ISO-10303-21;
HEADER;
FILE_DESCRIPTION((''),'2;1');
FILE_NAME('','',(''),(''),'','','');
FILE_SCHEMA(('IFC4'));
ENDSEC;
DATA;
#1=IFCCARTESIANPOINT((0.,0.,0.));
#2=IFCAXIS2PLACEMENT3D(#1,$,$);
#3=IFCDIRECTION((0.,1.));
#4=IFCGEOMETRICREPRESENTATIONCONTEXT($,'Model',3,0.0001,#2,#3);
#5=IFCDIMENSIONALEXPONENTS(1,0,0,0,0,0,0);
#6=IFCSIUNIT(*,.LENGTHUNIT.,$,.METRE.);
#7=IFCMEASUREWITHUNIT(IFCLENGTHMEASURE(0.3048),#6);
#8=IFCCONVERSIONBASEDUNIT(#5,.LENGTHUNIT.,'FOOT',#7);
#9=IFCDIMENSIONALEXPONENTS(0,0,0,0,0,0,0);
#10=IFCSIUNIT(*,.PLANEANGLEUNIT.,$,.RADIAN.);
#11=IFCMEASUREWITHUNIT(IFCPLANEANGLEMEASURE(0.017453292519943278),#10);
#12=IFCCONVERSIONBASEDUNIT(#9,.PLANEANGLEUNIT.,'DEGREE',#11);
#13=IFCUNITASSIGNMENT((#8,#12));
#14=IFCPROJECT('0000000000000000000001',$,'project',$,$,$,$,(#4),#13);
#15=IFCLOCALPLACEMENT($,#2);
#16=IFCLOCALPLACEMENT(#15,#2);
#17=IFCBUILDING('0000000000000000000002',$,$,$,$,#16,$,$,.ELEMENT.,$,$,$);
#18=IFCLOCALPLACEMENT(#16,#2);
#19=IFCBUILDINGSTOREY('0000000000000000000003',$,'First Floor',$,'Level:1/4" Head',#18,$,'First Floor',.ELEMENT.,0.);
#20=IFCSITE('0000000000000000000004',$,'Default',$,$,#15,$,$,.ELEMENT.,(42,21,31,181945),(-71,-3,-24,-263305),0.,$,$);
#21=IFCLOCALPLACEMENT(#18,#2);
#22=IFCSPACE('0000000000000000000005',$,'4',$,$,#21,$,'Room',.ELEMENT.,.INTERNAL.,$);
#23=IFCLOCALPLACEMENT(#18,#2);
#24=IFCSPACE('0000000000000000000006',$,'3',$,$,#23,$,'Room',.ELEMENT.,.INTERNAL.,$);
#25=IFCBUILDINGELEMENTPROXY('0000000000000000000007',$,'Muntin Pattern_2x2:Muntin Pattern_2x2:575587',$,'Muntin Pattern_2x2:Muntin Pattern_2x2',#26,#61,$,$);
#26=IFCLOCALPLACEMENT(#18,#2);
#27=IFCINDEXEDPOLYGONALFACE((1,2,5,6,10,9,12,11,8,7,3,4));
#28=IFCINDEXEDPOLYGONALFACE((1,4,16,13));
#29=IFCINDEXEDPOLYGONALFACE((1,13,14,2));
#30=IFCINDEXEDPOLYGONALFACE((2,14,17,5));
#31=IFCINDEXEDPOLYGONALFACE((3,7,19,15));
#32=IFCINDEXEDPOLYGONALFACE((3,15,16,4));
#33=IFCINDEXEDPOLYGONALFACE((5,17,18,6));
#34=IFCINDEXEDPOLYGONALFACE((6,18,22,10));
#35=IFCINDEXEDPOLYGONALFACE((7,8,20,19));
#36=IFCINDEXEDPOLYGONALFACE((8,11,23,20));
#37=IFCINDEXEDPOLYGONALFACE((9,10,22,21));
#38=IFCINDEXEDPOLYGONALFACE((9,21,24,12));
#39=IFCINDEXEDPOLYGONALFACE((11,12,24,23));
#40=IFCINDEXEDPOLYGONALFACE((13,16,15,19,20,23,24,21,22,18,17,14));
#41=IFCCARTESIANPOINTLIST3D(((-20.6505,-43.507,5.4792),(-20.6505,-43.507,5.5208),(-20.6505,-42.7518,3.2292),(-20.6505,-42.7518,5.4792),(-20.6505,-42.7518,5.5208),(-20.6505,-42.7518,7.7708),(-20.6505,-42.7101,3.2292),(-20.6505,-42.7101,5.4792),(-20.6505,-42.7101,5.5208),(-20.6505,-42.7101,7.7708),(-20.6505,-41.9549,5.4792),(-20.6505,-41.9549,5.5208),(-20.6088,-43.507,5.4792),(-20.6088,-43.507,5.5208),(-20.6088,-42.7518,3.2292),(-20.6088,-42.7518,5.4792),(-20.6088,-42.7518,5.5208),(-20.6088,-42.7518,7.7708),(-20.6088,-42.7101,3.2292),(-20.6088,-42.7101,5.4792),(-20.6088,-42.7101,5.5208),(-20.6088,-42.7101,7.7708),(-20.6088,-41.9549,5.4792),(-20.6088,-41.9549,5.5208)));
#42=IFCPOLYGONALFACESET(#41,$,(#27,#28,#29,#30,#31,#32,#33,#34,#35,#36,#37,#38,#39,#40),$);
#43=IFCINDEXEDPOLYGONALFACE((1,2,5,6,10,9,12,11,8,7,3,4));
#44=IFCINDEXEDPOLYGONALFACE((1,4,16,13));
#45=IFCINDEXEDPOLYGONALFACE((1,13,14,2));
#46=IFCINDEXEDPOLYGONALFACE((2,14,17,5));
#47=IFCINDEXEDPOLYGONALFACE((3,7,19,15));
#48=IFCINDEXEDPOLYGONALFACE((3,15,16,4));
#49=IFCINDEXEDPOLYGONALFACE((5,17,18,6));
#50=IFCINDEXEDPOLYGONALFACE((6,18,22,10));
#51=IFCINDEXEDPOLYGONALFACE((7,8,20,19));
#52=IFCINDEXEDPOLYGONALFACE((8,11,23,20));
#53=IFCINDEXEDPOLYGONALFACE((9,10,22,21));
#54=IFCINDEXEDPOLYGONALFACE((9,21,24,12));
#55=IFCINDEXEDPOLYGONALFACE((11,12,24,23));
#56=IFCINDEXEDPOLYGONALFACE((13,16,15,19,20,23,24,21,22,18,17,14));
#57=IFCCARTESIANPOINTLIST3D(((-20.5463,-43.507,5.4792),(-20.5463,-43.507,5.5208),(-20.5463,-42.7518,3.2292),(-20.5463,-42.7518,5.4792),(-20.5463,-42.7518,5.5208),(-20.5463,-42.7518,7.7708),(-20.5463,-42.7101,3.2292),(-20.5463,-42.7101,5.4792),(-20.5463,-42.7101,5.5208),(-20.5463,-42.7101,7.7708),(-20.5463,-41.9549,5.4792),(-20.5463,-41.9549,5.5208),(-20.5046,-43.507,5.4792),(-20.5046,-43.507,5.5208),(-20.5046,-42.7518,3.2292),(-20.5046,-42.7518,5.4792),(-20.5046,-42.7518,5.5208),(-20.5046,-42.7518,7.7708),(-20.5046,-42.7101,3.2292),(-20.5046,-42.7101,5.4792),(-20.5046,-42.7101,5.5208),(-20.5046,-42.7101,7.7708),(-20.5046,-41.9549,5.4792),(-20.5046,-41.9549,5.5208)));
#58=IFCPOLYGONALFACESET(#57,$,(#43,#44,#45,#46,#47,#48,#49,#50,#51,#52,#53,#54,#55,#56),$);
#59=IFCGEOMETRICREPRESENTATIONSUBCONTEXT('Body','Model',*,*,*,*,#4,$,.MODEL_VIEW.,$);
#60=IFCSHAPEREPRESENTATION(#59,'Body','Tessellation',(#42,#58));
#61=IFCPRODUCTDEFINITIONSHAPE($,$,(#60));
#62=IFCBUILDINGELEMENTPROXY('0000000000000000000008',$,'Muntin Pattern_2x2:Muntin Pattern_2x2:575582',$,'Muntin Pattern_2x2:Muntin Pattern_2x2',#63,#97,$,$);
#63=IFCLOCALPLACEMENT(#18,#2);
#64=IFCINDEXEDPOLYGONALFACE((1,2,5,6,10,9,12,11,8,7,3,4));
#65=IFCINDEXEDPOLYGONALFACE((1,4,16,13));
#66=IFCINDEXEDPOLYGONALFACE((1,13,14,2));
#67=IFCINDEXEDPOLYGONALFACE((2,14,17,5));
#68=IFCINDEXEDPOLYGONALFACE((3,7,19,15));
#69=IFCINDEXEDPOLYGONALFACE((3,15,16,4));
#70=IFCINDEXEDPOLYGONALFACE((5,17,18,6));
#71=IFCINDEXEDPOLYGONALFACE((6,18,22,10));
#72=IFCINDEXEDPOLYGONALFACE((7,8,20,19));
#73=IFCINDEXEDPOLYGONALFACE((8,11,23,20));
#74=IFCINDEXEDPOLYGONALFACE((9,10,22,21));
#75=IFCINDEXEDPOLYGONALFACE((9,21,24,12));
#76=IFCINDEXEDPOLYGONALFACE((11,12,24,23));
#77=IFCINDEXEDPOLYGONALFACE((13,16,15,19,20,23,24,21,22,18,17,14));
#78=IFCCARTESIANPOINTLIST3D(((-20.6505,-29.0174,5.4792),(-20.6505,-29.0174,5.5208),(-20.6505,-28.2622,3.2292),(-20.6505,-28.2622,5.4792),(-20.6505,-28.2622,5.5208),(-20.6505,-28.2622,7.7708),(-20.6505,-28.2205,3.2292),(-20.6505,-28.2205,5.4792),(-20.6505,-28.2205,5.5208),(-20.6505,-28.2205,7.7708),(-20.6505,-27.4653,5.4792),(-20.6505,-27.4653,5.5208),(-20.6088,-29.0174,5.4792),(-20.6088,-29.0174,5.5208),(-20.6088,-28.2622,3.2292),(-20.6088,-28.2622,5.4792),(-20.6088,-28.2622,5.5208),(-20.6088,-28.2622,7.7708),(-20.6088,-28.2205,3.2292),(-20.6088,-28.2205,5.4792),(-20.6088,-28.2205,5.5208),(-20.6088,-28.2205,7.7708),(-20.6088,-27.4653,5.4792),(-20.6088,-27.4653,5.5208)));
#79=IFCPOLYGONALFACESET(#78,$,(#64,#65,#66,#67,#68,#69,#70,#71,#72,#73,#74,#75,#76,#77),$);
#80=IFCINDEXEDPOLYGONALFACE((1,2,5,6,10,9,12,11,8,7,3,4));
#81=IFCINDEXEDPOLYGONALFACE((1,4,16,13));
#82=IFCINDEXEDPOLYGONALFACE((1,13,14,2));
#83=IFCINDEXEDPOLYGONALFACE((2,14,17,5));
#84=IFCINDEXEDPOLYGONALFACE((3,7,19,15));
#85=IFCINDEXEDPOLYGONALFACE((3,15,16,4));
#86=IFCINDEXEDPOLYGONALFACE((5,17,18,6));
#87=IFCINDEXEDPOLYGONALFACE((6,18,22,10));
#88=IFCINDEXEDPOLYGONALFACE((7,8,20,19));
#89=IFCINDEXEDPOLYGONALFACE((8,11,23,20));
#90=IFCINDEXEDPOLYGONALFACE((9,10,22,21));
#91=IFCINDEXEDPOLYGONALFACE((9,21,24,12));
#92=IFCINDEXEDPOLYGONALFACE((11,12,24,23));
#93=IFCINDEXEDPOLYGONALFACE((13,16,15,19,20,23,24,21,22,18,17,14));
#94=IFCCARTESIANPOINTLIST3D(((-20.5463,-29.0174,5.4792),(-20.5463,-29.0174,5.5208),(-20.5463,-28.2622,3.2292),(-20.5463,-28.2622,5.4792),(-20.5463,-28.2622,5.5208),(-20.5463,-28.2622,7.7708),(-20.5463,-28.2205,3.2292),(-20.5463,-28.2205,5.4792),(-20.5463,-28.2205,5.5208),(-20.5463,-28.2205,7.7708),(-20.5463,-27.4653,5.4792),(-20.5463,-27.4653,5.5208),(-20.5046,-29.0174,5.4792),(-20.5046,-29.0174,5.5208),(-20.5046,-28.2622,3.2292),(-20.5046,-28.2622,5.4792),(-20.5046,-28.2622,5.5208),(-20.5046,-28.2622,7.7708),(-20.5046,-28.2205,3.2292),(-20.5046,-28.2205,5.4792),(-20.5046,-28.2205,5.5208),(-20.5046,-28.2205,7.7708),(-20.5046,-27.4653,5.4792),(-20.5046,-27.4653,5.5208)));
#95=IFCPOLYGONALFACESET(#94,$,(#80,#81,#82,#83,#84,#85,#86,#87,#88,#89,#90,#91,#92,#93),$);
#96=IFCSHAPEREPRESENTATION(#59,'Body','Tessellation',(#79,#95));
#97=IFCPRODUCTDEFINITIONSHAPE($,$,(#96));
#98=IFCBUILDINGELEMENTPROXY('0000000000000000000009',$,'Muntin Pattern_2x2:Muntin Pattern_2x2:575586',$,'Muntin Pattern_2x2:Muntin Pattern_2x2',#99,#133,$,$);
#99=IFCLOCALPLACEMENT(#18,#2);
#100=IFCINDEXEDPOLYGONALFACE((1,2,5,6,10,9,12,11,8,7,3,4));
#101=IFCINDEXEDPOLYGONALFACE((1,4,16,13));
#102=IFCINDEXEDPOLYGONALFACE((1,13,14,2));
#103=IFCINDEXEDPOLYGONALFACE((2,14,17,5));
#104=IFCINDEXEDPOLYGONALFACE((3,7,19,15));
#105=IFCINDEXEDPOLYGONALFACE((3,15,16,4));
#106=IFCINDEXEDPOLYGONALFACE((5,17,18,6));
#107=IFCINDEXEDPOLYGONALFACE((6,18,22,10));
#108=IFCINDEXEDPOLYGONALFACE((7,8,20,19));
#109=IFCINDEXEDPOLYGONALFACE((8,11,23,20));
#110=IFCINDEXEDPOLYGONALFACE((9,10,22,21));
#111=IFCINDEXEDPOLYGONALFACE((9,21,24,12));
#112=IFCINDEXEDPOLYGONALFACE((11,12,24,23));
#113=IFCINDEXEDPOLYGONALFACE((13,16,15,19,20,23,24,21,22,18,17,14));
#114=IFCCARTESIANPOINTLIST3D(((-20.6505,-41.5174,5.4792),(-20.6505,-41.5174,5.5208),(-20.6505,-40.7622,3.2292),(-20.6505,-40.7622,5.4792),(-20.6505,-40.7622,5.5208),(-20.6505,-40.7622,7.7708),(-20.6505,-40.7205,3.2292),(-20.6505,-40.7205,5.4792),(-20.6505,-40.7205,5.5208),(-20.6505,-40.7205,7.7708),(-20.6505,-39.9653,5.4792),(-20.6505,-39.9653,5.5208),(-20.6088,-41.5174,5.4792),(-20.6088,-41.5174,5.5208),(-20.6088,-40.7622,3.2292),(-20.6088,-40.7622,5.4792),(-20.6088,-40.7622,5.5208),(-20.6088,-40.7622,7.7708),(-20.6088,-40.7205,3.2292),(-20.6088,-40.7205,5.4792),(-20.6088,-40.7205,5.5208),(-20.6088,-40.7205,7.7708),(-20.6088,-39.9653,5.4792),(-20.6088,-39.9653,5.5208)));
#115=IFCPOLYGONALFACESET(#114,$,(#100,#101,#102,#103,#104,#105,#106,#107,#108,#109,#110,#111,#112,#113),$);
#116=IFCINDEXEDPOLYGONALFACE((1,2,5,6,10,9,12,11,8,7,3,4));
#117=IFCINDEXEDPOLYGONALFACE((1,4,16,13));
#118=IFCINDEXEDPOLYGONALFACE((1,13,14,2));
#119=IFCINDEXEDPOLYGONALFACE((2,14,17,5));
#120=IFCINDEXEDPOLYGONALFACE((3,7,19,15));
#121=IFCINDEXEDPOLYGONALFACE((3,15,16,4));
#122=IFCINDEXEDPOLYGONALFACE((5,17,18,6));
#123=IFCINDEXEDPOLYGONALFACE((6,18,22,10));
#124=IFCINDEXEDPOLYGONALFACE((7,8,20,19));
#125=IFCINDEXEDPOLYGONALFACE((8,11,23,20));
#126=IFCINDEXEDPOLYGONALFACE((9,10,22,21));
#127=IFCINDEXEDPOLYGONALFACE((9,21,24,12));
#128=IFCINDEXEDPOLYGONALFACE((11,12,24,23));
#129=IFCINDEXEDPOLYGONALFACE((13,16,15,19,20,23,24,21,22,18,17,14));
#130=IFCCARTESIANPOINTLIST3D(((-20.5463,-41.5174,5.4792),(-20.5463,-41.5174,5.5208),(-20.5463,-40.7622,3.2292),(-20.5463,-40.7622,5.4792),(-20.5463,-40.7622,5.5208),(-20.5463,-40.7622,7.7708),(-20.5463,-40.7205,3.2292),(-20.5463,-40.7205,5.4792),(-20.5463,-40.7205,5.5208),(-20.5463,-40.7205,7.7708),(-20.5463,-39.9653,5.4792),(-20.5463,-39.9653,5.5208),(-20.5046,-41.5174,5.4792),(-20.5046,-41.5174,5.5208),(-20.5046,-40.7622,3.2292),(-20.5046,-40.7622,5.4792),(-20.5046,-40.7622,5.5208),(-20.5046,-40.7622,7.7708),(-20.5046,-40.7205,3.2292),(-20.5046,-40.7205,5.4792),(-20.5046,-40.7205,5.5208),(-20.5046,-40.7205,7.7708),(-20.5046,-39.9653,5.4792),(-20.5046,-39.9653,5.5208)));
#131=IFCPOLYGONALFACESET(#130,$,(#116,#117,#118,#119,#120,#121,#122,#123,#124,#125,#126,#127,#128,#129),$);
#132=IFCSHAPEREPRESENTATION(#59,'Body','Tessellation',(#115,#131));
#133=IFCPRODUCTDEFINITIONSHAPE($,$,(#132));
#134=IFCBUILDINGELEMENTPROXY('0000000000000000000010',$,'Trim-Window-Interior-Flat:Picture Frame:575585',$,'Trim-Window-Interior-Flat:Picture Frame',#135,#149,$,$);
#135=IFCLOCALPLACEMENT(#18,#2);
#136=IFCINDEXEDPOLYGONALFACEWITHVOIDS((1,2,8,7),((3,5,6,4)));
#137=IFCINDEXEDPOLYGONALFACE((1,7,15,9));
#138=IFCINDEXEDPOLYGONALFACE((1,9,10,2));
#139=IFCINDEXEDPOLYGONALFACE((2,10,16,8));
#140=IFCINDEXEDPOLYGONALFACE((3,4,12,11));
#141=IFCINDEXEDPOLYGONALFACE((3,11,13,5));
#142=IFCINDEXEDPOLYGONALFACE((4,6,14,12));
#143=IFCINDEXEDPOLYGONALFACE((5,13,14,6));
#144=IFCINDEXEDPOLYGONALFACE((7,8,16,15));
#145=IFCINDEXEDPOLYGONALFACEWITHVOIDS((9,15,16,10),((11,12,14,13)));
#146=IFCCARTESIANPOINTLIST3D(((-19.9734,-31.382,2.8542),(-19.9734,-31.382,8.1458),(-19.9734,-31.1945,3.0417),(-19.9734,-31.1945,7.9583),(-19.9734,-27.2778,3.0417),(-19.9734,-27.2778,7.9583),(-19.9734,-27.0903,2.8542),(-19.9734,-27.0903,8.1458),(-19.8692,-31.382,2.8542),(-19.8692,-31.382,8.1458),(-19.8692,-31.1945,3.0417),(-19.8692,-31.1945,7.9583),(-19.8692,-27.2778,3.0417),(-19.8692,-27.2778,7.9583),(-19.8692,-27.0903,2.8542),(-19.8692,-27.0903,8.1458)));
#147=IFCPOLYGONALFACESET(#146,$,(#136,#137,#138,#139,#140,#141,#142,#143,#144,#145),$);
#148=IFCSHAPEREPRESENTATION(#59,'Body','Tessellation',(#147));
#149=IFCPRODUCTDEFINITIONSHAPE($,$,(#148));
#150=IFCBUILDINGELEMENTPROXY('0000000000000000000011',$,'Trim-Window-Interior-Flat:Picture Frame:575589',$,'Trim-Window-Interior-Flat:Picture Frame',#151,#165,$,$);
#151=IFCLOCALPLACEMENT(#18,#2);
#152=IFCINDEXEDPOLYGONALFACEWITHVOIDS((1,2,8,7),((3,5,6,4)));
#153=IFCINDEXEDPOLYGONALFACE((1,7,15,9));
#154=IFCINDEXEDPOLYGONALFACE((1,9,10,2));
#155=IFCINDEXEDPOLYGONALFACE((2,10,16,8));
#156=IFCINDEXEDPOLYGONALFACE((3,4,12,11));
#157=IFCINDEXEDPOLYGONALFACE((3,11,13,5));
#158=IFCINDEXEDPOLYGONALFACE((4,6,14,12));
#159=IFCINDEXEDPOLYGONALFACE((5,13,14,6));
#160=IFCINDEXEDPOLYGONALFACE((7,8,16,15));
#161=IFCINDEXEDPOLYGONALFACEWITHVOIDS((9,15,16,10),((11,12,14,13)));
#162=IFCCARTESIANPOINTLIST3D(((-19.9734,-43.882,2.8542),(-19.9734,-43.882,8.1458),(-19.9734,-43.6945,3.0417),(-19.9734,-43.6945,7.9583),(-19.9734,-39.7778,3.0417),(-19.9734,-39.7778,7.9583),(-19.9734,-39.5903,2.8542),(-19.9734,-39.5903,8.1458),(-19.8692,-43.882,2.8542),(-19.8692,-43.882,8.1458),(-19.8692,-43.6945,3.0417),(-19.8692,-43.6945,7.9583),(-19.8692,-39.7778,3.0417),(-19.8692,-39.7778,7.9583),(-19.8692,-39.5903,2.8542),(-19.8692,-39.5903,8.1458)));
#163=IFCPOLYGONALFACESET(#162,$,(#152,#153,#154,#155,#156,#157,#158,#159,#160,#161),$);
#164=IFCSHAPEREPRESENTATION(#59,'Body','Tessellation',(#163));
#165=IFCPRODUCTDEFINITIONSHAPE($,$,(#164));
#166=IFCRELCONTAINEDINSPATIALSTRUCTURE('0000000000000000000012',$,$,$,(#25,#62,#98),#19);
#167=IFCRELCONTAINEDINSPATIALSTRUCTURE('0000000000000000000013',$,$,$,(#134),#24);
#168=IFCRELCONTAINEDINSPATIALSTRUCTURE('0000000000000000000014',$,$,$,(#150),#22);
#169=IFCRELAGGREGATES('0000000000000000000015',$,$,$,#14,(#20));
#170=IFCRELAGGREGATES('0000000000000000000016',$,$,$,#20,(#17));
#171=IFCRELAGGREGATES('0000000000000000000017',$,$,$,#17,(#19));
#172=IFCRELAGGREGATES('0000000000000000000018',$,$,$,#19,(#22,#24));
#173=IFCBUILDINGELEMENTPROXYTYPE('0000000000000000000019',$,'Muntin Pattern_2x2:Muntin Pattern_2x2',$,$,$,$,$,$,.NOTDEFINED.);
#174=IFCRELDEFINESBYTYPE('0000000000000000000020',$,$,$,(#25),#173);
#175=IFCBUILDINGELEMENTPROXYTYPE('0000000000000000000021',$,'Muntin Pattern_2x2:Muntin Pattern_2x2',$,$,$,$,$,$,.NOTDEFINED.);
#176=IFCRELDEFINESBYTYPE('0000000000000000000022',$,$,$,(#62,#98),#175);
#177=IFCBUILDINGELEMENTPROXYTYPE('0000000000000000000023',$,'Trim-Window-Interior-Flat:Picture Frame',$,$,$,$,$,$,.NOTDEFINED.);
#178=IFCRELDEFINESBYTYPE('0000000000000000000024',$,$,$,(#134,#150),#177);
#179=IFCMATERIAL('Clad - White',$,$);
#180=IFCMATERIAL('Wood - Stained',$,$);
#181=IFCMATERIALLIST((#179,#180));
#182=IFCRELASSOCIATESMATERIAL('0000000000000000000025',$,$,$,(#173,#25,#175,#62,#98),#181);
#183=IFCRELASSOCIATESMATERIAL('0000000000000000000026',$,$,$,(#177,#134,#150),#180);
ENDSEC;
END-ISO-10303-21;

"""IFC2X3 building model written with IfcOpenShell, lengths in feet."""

from ifc_helpers import new_model, entity, si_unit, converted_unit, direction, frame, origin, place, context, subcontext, project, spatial, polyline, outline, extrude, source, transform, mapped, material, material_list, type_object, type_shapes, element, save


model = new_model("IFC2X3")

# Units and contexts
model_context = context("Model", 3, precision=0.0001, world=origin(), true_north=direction((0.0, 1.0)))
body_context = subcontext(model_context, "Body", "Model", "MODEL_VIEW")
ifc_project = project(units=[converted_unit("LENGTHUNIT", "FOOT", entity("IfcLengthMeasure", 0.3048), si_unit("LENGTHUNIT", "METRE"), dimensions=[1, 0, 0, 0, 0, 0, 0]), converted_unit("PLANEANGLEUNIT", "DEGREE", entity("IfcPlaneAngleMeasure", 0.017453292519943278), si_unit("PLANEANGLEUNIT", "RADIAN"), dimensions=[0, 0, 0, 0, 0, 0, 0])], contexts=[model_context])

# Site, building, storey
site_placement = place(None, origin())
site = spatial("IfcSite", under=ifc_project, at=site_placement, Name="Default", CompositionType="ELEMENT", RefLatitude=(42, 21, 31, 181945), RefLongitude=(-71, -3, -24, -263305), RefElevation=0.0)
building_placement = place(site_placement, origin())
building = spatial("IfcBuilding", under=site, at=building_placement, CompositionType="ELEMENT")
storey_placement = place(building_placement, origin())
storey = spatial("IfcBuildingStorey", under=building, at=storey_placement, Name="First Floor", ObjectType="Level:1/4\" Head", LongName="First Floor", CompositionType="ELEMENT", Elevation=0.0)

# Shared definitions
space_1_placement = place(storey_placement, origin())
space_1 = spatial("IfcSpace", under=storey, at=space_1_placement, Name="4", LongName="Room", CompositionType="ELEMENT", InteriorOrExteriorSpace="INTERNAL")

# Building element proxies
ifc_material_1 = material(Name="Clad - White")
ifc_material_2 = material(Name="Wood - Stained")
ifc_material_list_1 = material_list([ifc_material_1, ifc_material_2])
building_element_proxy_type_1 = type_object("IfcBuildingElementProxyType", Name="Muntin Pattern_2x2:Muntin Pattern_2x2", PredefinedType="NOTDEFINED", material=ifc_material_list_1)
shared_shape_1 = source(origin(), body_context, "Body", "SweptSolid", [
    extrude(outline(polyline([(0.0208, -0.0208), (2.2708, -0.0208), (2.2708, 0.0208), (0.0208, 0.0208), (0.0208, 0.776), (-0.0208, 0.776), (-0.0208, 0.0208), (-2.2708, 0.0208), (-2.2708, -0.0208), (-0.0208, -0.0208), (-0.0208, -0.776), (0.0208, -0.776), (0.0208, -0.0208)])), frame((0.0, 0.0313, 2.2708), z_axis=(0.0, 1.0, 0.0), x_axis=(0.0, 0.0, 1.0)), (0.0, 0.0, 1.0), 0.0417),
    extrude(outline(polyline([(0.0208, -0.0208), (2.2708, -0.0208), (2.2708, 0.0208), (0.0208, 0.0208), (0.0208, 0.776), (-0.0208, 0.776), (-0.0208, 0.0208), (-2.2708, 0.0208), (-2.2708, -0.0208), (-0.0208, -0.0208), (-0.0208, -0.776), (0.0208, -0.776), (0.0208, -0.0208)])), frame((0.0, -0.0729, 2.2708), z_axis=(0.0, 1.0, 0.0), x_axis=(0.0, 0.0, 1.0)), (0.0, 0.0, 1.0), 0.0417),
])
type_shapes(building_element_proxy_type_1, [shared_shape_1])
for number, where, z_axis, x_axis, name in (
    (1, (-20.5775, -42.7309, 3.2292), (0.0, 0.0, 1.0), (0.0, 1.0, 0.0), "Muntin Pattern_2x2:Muntin Pattern_2x2:575587"),
):
    element("IfcBuildingElementProxy", number, at=place(storey_placement, frame(where, z_axis=z_axis, x_axis=x_axis)), inside=storey, type_object=building_element_proxy_type_1, material=ifc_material_list_1, Name=name, ObjectType="Muntin Pattern_2x2:Muntin Pattern_2x2", context=body_context, shape_type="MappedRepresentation", body=[
        mapped(shared_shape_1, transform((0.0, 0.0, 0.0), scale=1.0)),
    ])
building_element_proxy_type_2 = type_object("IfcBuildingElementProxyType", Name="Muntin Pattern_2x2:Muntin Pattern_2x2", PredefinedType="NOTDEFINED", material=ifc_material_list_1)
shared_shape_2 = source(origin(), body_context, "Body", "SweptSolid", [
    extrude(outline(polyline([(0.0208, -0.0208), (2.2708, -0.0208), (2.2708, 0.0208), (0.0208, 0.0208), (0.0208, 0.776), (-0.0208, 0.776), (-0.0208, 0.0208), (-2.2708, 0.0208), (-2.2708, -0.0208), (-0.0208, -0.0208), (-0.0208, -0.776), (0.0208, -0.776), (0.0208, -0.0208)])), frame((0.0, -0.0729, 2.2708), z_axis=(0.0, 1.0, 0.0), x_axis=(0.0, 0.0, 1.0)), (0.0, 0.0, 1.0), 0.0417),
    extrude(outline(polyline([(0.0208, -0.0208), (2.2708, -0.0208), (2.2708, 0.0208), (0.0208, 0.0208), (0.0208, 0.776), (-0.0208, 0.776), (-0.0208, 0.0208), (-2.2708, 0.0208), (-2.2708, -0.0208), (-0.0208, -0.0208), (-0.0208, -0.776), (0.0208, -0.776), (0.0208, -0.0208)])), frame((0.0, 0.0313, 2.2708), z_axis=(0.0, 1.0, 0.0), x_axis=(0.0, 0.0, 1.0)), (0.0, 0.0, 1.0), 0.0417),
])
type_shapes(building_element_proxy_type_2, [shared_shape_2])
for number, where, z_axis, x_axis, name in (
    (2, (-20.5775, -28.2413, 3.2292), (0.0, 0.0, 1.0), (0.0, -1.0, 0.0), "Muntin Pattern_2x2:Muntin Pattern_2x2:575582"),
    (3, (-20.5775, -40.7413, 3.2292), (0.0, 0.0, 1.0), (0.0, -1.0, 0.0), "Muntin Pattern_2x2:Muntin Pattern_2x2:575586"),
):
    element("IfcBuildingElementProxy", number, at=place(storey_placement, frame(where, z_axis=z_axis, x_axis=x_axis)), inside=storey, type_object=building_element_proxy_type_2, material=ifc_material_list_1, Name=name, ObjectType="Muntin Pattern_2x2:Muntin Pattern_2x2", context=body_context, shape_type="MappedRepresentation", body=[
        mapped(shared_shape_2, transform((0.0, 0.0, 0.0), scale=1.0)),
    ])

# Shared definitions
space_2_placement = place(storey_placement, origin())
space_2 = spatial("IfcSpace", under=storey, at=space_2_placement, Name="3", LongName="Room", CompositionType="ELEMENT", InteriorOrExteriorSpace="INTERNAL")

# Building element proxies
building_element_proxy_type_3 = type_object("IfcBuildingElementProxyType", Name="Trim-Window-Interior-Flat:Picture Frame", PredefinedType="NOTDEFINED", material=ifc_material_2)
shared_shape_3 = source(origin(), body_context, "Body", "SweptSolid", [
    extrude(outline(polyline([(-2.6458, -2.1458), (2.6458, -2.1458), (2.6458, 2.1458), (-2.6458, 2.1458), (-2.6458, -2.1458)]), holes=[polyline([(-2.4583, -1.9583), (-2.4583, 1.9583), (2.4583, 1.9583), (2.4583, -1.9583), (-2.4583, -1.9583)])]), frame((0.0, 2.5, 0.0), z_axis=(0.0, 0.0, 1.0), x_axis=(0.0, 1.0, 0.0)), (0.0, 0.0, 1.0), 0.1042),
])
type_shapes(building_element_proxy_type_3, [shared_shape_3])
proxy_1_placement = place(space_2_placement, frame((-19.9734, -29.2361, 8.0), z_axis=(1.0, 0.0, 0.0), x_axis=(0.0, -1.0, 0.0)))
element("IfcBuildingElementProxy", 4, at=proxy_1_placement, inside=space_2, type_object=building_element_proxy_type_3, material=ifc_material_2, Name="Trim-Window-Interior-Flat:Picture Frame:575585", ObjectType="Trim-Window-Interior-Flat:Picture Frame", context=body_context, shape_type="MappedRepresentation", body=[
    mapped(shared_shape_3, transform((0.0, 0.0, 0.0), scale=1.0)),
])
proxy_2_placement = place(space_1_placement, frame((-19.9734, -41.7361, 8.0), z_axis=(1.0, 0.0, 0.0), x_axis=(0.0, -1.0, 0.0)))
element("IfcBuildingElementProxy", 5, at=proxy_2_placement, inside=space_1, type_object=building_element_proxy_type_3, material=ifc_material_2, Name="Trim-Window-Interior-Flat:Picture Frame:575589", ObjectType="Trim-Window-Interior-Flat:Picture Frame", context=body_context, shape_type="MappedRepresentation", body=[
    mapped(shared_shape_3, transform((0.0, 0.0, 0.0), scale=1.0)),
])

save(model, "model.ifc")
